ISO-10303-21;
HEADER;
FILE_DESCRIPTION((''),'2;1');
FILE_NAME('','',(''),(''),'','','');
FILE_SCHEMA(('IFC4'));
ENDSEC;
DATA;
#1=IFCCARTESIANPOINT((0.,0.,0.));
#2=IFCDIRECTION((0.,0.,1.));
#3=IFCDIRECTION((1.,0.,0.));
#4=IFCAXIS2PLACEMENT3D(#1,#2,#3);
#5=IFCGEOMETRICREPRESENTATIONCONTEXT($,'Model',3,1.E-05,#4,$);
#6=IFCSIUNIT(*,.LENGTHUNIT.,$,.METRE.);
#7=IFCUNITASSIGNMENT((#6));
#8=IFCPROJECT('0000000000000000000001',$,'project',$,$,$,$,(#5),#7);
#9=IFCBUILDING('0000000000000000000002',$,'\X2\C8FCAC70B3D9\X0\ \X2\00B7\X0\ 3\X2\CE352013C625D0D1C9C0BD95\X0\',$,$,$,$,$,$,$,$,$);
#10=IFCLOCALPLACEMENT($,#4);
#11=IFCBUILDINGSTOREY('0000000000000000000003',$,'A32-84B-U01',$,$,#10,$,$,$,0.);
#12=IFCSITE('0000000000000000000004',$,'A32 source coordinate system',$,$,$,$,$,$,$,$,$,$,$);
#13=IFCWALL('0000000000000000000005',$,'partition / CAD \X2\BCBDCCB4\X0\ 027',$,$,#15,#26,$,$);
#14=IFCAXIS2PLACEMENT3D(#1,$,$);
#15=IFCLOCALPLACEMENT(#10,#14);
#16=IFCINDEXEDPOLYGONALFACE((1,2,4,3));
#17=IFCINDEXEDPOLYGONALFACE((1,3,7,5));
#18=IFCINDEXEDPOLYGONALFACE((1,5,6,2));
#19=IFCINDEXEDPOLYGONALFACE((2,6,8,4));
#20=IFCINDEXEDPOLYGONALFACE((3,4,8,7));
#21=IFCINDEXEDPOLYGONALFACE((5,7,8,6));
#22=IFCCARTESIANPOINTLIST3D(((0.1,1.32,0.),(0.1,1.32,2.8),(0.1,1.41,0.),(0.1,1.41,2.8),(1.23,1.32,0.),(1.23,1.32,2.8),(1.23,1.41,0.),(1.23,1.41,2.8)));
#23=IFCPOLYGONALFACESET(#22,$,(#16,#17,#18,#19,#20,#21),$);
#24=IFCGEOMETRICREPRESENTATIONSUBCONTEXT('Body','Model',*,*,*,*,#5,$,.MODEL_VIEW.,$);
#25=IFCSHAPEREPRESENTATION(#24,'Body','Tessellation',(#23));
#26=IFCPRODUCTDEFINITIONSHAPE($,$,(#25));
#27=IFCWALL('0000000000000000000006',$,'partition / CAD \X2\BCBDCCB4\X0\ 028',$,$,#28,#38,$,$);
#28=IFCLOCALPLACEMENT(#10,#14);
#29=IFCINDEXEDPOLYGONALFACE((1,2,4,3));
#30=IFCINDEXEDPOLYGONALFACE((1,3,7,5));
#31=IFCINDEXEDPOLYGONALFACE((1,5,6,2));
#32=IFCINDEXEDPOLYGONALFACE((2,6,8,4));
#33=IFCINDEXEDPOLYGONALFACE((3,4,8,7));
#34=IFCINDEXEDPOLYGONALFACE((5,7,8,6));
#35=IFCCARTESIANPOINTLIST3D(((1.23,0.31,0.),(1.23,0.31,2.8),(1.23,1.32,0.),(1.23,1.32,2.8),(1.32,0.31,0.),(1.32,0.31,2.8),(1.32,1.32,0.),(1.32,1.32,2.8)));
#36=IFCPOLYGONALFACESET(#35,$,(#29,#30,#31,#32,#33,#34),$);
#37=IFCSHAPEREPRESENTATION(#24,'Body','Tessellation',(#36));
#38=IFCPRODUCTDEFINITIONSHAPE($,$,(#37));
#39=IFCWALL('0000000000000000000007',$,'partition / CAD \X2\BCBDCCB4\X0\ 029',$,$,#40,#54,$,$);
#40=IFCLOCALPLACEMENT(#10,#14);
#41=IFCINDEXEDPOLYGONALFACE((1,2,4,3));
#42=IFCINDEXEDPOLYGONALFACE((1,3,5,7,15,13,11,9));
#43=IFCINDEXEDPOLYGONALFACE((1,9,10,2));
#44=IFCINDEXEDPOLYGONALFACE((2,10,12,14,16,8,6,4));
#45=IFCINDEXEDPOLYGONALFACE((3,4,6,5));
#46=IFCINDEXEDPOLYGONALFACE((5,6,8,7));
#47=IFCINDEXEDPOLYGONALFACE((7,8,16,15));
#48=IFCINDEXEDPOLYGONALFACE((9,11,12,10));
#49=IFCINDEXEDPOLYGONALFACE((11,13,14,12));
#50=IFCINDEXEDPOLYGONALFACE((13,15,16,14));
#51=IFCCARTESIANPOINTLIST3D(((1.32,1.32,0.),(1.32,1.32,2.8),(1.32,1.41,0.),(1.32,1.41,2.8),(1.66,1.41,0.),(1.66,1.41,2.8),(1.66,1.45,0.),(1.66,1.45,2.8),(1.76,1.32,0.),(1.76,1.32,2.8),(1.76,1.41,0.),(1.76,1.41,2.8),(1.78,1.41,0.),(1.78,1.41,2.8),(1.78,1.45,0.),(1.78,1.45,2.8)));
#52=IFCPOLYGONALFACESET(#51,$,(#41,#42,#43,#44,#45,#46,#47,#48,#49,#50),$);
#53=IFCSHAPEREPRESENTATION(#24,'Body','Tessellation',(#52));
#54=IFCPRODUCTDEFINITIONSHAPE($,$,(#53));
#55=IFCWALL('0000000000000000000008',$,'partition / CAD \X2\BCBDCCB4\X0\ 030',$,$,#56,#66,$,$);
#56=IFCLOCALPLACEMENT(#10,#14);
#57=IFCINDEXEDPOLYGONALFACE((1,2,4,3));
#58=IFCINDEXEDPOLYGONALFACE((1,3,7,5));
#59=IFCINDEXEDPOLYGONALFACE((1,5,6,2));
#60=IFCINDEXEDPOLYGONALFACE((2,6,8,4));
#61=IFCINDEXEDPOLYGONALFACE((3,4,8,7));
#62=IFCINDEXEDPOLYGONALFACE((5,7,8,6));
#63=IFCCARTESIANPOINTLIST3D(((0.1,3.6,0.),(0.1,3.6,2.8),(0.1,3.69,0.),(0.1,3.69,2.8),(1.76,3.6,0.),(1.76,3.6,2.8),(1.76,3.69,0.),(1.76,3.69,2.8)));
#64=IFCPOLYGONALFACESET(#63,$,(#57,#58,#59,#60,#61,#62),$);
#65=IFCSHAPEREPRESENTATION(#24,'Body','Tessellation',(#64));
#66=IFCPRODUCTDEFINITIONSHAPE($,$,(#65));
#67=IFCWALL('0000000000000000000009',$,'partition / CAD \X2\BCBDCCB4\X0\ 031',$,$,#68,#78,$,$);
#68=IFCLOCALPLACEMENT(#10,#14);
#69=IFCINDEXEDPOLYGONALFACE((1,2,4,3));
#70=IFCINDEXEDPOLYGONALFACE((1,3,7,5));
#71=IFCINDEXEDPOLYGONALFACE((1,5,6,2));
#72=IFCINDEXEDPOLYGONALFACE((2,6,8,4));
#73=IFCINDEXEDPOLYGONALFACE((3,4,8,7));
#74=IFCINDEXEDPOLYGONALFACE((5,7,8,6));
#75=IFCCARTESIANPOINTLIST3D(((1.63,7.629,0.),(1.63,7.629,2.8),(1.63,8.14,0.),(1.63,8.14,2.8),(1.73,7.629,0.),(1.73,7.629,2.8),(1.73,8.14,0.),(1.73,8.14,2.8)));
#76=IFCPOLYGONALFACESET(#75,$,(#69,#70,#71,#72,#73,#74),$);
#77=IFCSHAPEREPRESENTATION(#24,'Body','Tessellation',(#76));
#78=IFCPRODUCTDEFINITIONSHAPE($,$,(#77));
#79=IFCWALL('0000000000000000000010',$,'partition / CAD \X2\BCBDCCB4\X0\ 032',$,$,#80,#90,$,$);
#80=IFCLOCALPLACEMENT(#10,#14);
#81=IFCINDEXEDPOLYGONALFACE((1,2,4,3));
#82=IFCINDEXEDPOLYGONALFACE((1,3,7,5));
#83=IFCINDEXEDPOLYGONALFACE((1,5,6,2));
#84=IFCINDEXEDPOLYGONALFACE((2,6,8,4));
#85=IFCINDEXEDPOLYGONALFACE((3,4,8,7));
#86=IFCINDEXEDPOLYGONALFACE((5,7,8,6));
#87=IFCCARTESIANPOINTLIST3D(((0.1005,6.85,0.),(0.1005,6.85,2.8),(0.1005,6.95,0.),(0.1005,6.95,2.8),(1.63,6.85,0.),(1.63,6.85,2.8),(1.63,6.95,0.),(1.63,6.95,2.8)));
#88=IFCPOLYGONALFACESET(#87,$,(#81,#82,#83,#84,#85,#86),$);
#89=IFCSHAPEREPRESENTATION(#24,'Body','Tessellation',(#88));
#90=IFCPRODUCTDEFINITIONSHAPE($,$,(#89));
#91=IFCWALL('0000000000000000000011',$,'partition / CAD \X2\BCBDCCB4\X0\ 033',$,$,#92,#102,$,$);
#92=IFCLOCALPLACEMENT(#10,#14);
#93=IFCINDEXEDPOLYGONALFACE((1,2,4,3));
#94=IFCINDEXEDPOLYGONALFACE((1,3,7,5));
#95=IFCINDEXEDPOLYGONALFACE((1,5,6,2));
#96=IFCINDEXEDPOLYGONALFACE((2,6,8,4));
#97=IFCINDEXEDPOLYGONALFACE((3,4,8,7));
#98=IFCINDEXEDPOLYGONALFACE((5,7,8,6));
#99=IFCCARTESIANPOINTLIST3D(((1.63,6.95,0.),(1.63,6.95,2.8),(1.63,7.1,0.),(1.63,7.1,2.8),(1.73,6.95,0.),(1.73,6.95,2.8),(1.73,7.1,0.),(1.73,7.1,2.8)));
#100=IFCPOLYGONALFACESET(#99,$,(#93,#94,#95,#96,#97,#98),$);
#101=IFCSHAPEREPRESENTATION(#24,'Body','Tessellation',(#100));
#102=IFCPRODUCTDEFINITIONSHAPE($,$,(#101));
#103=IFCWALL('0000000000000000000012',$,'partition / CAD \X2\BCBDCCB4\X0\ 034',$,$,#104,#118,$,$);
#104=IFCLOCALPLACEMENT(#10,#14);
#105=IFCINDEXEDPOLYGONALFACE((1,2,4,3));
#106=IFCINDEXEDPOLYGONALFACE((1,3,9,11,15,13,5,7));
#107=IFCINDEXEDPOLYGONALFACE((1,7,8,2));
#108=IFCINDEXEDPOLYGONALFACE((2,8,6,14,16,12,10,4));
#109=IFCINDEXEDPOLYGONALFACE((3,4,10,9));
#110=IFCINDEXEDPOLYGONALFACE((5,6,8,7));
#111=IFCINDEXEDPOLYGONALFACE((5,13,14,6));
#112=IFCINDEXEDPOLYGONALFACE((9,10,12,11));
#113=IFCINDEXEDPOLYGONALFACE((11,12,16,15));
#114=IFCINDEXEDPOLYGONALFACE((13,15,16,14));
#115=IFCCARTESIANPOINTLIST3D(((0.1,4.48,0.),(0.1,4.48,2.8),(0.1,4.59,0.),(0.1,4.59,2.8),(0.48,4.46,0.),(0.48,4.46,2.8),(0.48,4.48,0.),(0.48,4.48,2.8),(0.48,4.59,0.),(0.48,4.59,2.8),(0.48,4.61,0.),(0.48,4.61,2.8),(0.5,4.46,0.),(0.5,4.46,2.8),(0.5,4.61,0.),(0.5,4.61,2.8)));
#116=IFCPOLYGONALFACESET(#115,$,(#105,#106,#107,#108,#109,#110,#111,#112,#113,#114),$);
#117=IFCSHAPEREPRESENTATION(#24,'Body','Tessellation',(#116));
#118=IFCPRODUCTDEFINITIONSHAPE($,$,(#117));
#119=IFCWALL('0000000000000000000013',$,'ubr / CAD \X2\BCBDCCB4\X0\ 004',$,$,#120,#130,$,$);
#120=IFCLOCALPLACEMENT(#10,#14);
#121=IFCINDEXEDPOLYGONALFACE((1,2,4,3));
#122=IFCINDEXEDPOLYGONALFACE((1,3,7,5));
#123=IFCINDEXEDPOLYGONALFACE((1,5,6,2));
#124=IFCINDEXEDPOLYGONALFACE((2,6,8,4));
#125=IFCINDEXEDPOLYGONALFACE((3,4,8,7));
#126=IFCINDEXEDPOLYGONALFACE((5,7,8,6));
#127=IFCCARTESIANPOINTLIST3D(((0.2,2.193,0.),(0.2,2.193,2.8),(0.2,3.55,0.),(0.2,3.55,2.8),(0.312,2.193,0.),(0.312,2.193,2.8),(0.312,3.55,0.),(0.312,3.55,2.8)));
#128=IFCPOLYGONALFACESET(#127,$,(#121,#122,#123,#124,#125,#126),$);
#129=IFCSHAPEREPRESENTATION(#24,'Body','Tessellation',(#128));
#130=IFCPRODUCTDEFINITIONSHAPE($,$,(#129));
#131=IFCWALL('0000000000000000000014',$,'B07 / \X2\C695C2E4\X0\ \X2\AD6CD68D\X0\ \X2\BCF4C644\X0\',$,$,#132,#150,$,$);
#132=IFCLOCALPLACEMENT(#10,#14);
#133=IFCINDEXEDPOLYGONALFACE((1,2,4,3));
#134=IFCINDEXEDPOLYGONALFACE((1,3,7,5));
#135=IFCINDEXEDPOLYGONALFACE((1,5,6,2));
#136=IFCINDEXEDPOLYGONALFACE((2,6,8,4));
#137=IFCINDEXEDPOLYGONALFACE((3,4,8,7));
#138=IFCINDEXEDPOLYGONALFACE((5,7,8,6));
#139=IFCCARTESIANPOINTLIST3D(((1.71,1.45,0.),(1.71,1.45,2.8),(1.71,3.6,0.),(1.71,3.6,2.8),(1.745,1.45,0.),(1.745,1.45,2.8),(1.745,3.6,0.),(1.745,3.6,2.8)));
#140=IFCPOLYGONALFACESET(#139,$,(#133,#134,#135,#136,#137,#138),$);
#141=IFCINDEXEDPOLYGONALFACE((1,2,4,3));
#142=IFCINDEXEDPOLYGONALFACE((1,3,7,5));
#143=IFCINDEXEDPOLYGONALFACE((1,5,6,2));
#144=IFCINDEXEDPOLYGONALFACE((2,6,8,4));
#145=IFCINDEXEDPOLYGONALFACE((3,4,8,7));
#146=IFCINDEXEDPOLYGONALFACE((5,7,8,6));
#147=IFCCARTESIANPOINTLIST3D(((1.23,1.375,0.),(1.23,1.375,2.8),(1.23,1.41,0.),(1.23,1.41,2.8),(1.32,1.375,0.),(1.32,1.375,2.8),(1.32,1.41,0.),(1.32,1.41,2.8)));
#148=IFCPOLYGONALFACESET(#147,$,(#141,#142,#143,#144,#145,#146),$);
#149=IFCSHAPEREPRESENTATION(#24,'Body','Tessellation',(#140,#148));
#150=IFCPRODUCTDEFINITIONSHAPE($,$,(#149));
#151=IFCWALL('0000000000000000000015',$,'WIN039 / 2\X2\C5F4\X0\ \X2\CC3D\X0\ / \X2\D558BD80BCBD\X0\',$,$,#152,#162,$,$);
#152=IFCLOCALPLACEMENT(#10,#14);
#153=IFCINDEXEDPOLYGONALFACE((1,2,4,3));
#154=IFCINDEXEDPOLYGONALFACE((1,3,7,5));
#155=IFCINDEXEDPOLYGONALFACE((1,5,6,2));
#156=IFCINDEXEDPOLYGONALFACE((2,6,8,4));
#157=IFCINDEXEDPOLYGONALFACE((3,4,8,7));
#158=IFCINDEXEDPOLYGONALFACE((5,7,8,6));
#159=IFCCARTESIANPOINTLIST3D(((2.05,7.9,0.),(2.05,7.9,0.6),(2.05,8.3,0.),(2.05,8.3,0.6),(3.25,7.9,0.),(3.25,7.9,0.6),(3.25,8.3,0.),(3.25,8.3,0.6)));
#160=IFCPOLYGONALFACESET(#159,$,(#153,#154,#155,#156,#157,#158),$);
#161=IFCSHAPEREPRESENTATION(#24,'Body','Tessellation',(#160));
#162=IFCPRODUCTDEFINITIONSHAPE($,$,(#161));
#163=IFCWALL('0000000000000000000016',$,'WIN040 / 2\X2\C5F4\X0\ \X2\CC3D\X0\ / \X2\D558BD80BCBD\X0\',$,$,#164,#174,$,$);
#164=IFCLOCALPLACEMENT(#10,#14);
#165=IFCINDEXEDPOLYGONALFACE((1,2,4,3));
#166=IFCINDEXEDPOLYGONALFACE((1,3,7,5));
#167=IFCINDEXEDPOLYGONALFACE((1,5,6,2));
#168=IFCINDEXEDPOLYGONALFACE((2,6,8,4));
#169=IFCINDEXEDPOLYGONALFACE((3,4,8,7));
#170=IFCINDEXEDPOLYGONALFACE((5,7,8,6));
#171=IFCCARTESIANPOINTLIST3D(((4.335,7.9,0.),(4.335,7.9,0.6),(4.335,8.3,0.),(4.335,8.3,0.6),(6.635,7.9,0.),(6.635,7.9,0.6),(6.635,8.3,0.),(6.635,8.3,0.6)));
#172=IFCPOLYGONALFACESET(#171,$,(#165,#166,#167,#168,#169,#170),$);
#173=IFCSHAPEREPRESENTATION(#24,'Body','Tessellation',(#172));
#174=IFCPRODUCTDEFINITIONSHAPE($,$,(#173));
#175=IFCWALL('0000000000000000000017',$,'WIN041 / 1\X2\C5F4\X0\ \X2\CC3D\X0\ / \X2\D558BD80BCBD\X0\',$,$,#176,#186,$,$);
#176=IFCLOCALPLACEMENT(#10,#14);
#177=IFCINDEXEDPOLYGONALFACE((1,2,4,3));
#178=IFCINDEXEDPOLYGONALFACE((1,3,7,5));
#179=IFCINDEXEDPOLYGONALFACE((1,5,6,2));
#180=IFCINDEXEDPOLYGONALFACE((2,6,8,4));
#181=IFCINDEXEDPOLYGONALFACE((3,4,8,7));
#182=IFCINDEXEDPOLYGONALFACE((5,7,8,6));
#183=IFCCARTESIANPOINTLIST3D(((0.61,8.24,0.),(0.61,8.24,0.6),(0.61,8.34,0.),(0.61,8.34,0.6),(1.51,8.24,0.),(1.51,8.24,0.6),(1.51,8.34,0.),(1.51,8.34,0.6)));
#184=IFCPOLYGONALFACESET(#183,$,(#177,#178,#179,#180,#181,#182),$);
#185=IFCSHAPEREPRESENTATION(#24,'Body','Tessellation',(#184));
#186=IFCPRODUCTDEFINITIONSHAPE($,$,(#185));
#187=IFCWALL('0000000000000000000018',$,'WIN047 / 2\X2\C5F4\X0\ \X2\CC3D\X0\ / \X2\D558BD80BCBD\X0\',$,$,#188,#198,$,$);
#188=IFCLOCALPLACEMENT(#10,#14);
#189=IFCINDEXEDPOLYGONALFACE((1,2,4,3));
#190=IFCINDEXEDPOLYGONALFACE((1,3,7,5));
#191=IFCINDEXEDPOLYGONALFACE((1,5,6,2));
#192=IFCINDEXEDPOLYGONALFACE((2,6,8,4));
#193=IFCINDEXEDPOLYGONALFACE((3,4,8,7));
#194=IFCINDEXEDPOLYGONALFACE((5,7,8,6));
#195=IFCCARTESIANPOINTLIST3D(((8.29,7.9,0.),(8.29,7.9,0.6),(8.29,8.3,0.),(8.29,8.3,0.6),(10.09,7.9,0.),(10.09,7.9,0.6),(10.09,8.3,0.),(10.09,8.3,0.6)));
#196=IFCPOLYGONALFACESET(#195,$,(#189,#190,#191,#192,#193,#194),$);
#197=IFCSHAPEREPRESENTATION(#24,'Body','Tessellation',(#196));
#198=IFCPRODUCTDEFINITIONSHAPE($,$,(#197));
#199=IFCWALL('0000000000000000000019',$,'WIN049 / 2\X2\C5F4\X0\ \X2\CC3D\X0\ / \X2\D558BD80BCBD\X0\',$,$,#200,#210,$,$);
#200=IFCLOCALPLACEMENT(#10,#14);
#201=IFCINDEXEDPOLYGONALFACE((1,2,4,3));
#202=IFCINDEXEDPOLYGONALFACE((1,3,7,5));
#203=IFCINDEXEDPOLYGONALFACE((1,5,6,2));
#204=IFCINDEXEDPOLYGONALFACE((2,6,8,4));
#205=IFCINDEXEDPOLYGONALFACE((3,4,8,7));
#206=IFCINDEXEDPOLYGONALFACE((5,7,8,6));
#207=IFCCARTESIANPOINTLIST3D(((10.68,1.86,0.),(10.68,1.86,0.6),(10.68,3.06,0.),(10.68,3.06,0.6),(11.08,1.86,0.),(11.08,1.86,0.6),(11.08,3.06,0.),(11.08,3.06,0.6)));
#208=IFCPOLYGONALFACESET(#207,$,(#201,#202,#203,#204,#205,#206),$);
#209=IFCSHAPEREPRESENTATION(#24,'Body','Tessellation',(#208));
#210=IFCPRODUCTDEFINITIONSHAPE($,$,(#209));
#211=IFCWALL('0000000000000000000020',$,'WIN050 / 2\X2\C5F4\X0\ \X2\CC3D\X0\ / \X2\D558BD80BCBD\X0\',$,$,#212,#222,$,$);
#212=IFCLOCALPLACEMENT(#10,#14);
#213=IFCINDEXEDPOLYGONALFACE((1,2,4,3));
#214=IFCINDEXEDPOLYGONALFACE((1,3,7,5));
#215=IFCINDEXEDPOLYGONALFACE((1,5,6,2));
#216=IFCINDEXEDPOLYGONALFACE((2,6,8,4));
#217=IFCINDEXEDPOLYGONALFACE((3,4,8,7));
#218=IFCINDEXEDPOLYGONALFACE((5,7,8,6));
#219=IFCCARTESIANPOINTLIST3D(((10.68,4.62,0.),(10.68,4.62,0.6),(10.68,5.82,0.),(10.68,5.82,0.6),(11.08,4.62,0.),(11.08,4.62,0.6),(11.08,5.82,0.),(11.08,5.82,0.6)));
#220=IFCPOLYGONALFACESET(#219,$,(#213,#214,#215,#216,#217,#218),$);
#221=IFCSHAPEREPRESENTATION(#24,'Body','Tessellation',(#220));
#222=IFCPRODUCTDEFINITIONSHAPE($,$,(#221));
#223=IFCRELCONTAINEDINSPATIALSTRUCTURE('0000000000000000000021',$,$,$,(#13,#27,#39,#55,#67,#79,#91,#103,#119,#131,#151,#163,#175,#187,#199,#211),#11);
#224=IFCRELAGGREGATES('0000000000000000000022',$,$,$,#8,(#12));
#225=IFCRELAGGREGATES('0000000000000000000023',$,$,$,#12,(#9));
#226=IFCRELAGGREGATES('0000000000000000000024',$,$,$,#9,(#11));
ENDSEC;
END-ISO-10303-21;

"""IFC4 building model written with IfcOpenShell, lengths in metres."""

from ifc_helpers import new_model, si_unit, origin, origin_with_axes, place, context, subcontext, project, spatial, polyline, outline, extrude, element, save


model = new_model("IFC4")

# Units and contexts
model_context = context("Model", 3, precision=1e-05, world=origin_with_axes())
body_context = subcontext(model_context, "Body", "Model", "MODEL_VIEW")
ifc_project = project(units=[si_unit("LENGTHUNIT", "METRE")], contexts=[model_context])

# Site, building, storey
site = spatial("IfcSite", under=ifc_project, Name="A32 source coordinate system")
building = spatial("IfcBuilding", under=site, Name="주거동 · 3층–옥탑지붕")
storey_placement = place(None, origin_with_axes())
storey = spatial("IfcBuildingStorey", under=building, at=storey_placement, Name="A32-84B-U01", Elevation=0.0)

# Walls
wall_1_placement = place(storey_placement, origin_with_axes())
element("IfcWall", 1, at=wall_1_placement, inside=storey, Name="partition / CAD 벽체 027", context=body_context, shape_type="SweptSolid", body=[
    extrude(outline(polyline([(0.1, 1.32), (0.1, 1.41), (1.23, 1.41), (1.23, 1.32), (0.1, 1.32)])), origin(), (0.0, 0.0, 1.0), 2.8),
])
wall_2_placement = place(storey_placement, origin_with_axes())
element("IfcWall", 2, at=wall_2_placement, inside=storey, Name="partition / CAD 벽체 028", context=body_context, shape_type="SweptSolid", body=[
    extrude(outline(polyline([(1.32, 0.31), (1.23, 0.31), (1.23, 1.32), (1.32, 1.32), (1.32, 0.31)])), origin(), (0.0, 0.0, 1.0), 2.8),
])
wall_3_placement = place(storey_placement, origin_with_axes())
element("IfcWall", 3, at=wall_3_placement, inside=storey, Name="partition / CAD 벽체 029", context=body_context, shape_type="SweptSolid", body=[
    extrude(outline(polyline([(1.66, 1.41), (1.66, 1.45), (1.78, 1.45), (1.78, 1.41), (1.76, 1.41), (1.76, 1.32), (1.32, 1.32), (1.32, 1.41), (1.66, 1.41)])), origin(), (0.0, 0.0, 1.0), 2.8),
])
wall_4_placement = place(storey_placement, origin_with_axes())
element("IfcWall", 4, at=wall_4_placement, inside=storey, Name="partition / CAD 벽체 030", context=body_context, shape_type="SweptSolid", body=[
    extrude(outline(polyline([(1.76, 3.69), (1.76, 3.6), (0.1, 3.6), (0.1, 3.69), (1.76, 3.69)])), origin(), (0.0, 0.0, 1.0), 2.8),
])
wall_5_placement = place(storey_placement, origin_with_axes())
element("IfcWall", 5, at=wall_5_placement, inside=storey, Name="partition / CAD 벽체 031", context=body_context, shape_type="SweptSolid", body=[
    extrude(outline(polyline([(1.63, 8.14), (1.73, 8.14), (1.73, 7.629), (1.63, 7.629), (1.63, 8.14)])), origin(), (0.0, 0.0, 1.0), 2.8),
])
wall_6_placement = place(storey_placement, origin_with_axes())
element("IfcWall", 6, at=wall_6_placement, inside=storey, Name="partition / CAD 벽체 032", context=body_context, shape_type="SweptSolid", body=[
    extrude(outline(polyline([(0.1005, 6.95), (1.63, 6.95), (1.63, 6.85), (0.1005, 6.85), (0.1005, 6.95)])), origin(), (0.0, 0.0, 1.0), 2.8),
])
wall_7_placement = place(storey_placement, origin_with_axes())
element("IfcWall", 7, at=wall_7_placement, inside=storey, Name="partition / CAD 벽체 033", context=body_context, shape_type="SweptSolid", body=[
    extrude(outline(polyline([(1.63, 7.1), (1.73, 7.1), (1.73, 6.95), (1.63, 6.95), (1.63, 7.1)])), origin(), (0.0, 0.0, 1.0), 2.8),
])
wall_8_placement = place(storey_placement, origin_with_axes())
element("IfcWall", 8, at=wall_8_placement, inside=storey, Name="partition / CAD 벽체 034", context=body_context, shape_type="SweptSolid", body=[
    extrude(outline(polyline([(0.48, 4.61), (0.5, 4.61), (0.5, 4.46), (0.48, 4.46), (0.48, 4.48), (0.1, 4.48), (0.1, 4.59), (0.48, 4.59), (0.48, 4.61)])), origin(), (0.0, 0.0, 1.0), 2.8),
])
wall_9_placement = place(storey_placement, origin_with_axes())
element("IfcWall", 9, at=wall_9_placement, inside=storey, Name="ubr / CAD 벽체 004", context=body_context, shape_type="SweptSolid", body=[
    extrude(outline(polyline([(0.312, 2.193), (0.2, 2.193), (0.2, 3.55), (0.312, 3.55), (0.312, 2.193)])), origin(), (0.0, 0.0, 1.0), 2.8),
])
wall_10_placement = place(storey_placement, origin_with_axes())
element("IfcWall", 10, at=wall_10_placement, inside=storey, Name="B07 / 욕실 구획 보완", context=body_context, shape_type="SweptSolid", body=[
    extrude(outline(polyline([(1.71, 1.45), (1.71, 3.6), (1.745, 3.6), (1.745, 1.45), (1.71, 1.45)])), origin(), (0.0, 0.0, 1.0), 2.8),
    extrude(outline(polyline([(1.32, 1.41), (1.32, 1.375), (1.23, 1.375), (1.23, 1.41), (1.32, 1.41)])), origin(), (0.0, 0.0, 1.0), 2.8),
])
wall_11_placement = place(storey_placement, origin_with_axes())
element("IfcWall", 11, at=wall_11_placement, inside=storey, Name="WIN039 / 2열 창 / 하부벽", context=body_context, shape_type="SweptSolid", body=[
    extrude(outline(polyline([(2.05, 8.3), (3.25, 8.3), (3.25, 7.9), (2.05, 7.9), (2.05, 8.3)])), origin(), (0.0, 0.0, 1.0), 0.6),
])
wall_12_placement = place(storey_placement, origin_with_axes())
element("IfcWall", 12, at=wall_12_placement, inside=storey, Name="WIN040 / 2열 창 / 하부벽", context=body_context, shape_type="SweptSolid", body=[
    extrude(outline(polyline([(4.335, 8.3), (6.635, 8.3), (6.635, 7.9), (4.335, 7.9), (4.335, 8.3)])), origin(), (0.0, 0.0, 1.0), 0.6),
])
wall_13_placement = place(storey_placement, origin_with_axes())
element("IfcWall", 13, at=wall_13_placement, inside=storey, Name="WIN041 / 1열 창 / 하부벽", context=body_context, shape_type="SweptSolid", body=[
    extrude(outline(polyline([(0.61, 8.34), (1.51, 8.34), (1.51, 8.24), (0.61, 8.24), (0.61, 8.34)])), origin(), (0.0, 0.0, 1.0), 0.6),
])
wall_14_placement = place(storey_placement, origin_with_axes())
element("IfcWall", 14, at=wall_14_placement, inside=storey, Name="WIN047 / 2열 창 / 하부벽", context=body_context, shape_type="SweptSolid", body=[
    extrude(outline(polyline([(8.29, 8.3), (10.09, 8.3), (10.09, 7.9), (8.29, 7.9), (8.29, 8.3)])), origin(), (0.0, 0.0, 1.0), 0.6),
])
wall_15_placement = place(storey_placement, origin_with_axes())
element("IfcWall", 15, at=wall_15_placement, inside=storey, Name="WIN049 / 2열 창 / 하부벽", context=body_context, shape_type="SweptSolid", body=[
    extrude(outline(polyline([(10.68, 3.06), (11.08, 3.06), (11.08, 1.86), (10.68, 1.86), (10.68, 3.06)])), origin(), (0.0, 0.0, 1.0), 0.6),
])
wall_16_placement = place(storey_placement, origin_with_axes())
element("IfcWall", 16, at=wall_16_placement, inside=storey, Name="WIN050 / 2열 창 / 하부벽", context=body_context, shape_type="SweptSolid", body=[
    extrude(outline(polyline([(10.68, 5.82), (11.08, 5.82), (11.08, 4.62), (10.68, 4.62), (10.68, 5.82)])), origin(), (0.0, 0.0, 1.0), 0.6),
])

save(model, "model.ifc")
